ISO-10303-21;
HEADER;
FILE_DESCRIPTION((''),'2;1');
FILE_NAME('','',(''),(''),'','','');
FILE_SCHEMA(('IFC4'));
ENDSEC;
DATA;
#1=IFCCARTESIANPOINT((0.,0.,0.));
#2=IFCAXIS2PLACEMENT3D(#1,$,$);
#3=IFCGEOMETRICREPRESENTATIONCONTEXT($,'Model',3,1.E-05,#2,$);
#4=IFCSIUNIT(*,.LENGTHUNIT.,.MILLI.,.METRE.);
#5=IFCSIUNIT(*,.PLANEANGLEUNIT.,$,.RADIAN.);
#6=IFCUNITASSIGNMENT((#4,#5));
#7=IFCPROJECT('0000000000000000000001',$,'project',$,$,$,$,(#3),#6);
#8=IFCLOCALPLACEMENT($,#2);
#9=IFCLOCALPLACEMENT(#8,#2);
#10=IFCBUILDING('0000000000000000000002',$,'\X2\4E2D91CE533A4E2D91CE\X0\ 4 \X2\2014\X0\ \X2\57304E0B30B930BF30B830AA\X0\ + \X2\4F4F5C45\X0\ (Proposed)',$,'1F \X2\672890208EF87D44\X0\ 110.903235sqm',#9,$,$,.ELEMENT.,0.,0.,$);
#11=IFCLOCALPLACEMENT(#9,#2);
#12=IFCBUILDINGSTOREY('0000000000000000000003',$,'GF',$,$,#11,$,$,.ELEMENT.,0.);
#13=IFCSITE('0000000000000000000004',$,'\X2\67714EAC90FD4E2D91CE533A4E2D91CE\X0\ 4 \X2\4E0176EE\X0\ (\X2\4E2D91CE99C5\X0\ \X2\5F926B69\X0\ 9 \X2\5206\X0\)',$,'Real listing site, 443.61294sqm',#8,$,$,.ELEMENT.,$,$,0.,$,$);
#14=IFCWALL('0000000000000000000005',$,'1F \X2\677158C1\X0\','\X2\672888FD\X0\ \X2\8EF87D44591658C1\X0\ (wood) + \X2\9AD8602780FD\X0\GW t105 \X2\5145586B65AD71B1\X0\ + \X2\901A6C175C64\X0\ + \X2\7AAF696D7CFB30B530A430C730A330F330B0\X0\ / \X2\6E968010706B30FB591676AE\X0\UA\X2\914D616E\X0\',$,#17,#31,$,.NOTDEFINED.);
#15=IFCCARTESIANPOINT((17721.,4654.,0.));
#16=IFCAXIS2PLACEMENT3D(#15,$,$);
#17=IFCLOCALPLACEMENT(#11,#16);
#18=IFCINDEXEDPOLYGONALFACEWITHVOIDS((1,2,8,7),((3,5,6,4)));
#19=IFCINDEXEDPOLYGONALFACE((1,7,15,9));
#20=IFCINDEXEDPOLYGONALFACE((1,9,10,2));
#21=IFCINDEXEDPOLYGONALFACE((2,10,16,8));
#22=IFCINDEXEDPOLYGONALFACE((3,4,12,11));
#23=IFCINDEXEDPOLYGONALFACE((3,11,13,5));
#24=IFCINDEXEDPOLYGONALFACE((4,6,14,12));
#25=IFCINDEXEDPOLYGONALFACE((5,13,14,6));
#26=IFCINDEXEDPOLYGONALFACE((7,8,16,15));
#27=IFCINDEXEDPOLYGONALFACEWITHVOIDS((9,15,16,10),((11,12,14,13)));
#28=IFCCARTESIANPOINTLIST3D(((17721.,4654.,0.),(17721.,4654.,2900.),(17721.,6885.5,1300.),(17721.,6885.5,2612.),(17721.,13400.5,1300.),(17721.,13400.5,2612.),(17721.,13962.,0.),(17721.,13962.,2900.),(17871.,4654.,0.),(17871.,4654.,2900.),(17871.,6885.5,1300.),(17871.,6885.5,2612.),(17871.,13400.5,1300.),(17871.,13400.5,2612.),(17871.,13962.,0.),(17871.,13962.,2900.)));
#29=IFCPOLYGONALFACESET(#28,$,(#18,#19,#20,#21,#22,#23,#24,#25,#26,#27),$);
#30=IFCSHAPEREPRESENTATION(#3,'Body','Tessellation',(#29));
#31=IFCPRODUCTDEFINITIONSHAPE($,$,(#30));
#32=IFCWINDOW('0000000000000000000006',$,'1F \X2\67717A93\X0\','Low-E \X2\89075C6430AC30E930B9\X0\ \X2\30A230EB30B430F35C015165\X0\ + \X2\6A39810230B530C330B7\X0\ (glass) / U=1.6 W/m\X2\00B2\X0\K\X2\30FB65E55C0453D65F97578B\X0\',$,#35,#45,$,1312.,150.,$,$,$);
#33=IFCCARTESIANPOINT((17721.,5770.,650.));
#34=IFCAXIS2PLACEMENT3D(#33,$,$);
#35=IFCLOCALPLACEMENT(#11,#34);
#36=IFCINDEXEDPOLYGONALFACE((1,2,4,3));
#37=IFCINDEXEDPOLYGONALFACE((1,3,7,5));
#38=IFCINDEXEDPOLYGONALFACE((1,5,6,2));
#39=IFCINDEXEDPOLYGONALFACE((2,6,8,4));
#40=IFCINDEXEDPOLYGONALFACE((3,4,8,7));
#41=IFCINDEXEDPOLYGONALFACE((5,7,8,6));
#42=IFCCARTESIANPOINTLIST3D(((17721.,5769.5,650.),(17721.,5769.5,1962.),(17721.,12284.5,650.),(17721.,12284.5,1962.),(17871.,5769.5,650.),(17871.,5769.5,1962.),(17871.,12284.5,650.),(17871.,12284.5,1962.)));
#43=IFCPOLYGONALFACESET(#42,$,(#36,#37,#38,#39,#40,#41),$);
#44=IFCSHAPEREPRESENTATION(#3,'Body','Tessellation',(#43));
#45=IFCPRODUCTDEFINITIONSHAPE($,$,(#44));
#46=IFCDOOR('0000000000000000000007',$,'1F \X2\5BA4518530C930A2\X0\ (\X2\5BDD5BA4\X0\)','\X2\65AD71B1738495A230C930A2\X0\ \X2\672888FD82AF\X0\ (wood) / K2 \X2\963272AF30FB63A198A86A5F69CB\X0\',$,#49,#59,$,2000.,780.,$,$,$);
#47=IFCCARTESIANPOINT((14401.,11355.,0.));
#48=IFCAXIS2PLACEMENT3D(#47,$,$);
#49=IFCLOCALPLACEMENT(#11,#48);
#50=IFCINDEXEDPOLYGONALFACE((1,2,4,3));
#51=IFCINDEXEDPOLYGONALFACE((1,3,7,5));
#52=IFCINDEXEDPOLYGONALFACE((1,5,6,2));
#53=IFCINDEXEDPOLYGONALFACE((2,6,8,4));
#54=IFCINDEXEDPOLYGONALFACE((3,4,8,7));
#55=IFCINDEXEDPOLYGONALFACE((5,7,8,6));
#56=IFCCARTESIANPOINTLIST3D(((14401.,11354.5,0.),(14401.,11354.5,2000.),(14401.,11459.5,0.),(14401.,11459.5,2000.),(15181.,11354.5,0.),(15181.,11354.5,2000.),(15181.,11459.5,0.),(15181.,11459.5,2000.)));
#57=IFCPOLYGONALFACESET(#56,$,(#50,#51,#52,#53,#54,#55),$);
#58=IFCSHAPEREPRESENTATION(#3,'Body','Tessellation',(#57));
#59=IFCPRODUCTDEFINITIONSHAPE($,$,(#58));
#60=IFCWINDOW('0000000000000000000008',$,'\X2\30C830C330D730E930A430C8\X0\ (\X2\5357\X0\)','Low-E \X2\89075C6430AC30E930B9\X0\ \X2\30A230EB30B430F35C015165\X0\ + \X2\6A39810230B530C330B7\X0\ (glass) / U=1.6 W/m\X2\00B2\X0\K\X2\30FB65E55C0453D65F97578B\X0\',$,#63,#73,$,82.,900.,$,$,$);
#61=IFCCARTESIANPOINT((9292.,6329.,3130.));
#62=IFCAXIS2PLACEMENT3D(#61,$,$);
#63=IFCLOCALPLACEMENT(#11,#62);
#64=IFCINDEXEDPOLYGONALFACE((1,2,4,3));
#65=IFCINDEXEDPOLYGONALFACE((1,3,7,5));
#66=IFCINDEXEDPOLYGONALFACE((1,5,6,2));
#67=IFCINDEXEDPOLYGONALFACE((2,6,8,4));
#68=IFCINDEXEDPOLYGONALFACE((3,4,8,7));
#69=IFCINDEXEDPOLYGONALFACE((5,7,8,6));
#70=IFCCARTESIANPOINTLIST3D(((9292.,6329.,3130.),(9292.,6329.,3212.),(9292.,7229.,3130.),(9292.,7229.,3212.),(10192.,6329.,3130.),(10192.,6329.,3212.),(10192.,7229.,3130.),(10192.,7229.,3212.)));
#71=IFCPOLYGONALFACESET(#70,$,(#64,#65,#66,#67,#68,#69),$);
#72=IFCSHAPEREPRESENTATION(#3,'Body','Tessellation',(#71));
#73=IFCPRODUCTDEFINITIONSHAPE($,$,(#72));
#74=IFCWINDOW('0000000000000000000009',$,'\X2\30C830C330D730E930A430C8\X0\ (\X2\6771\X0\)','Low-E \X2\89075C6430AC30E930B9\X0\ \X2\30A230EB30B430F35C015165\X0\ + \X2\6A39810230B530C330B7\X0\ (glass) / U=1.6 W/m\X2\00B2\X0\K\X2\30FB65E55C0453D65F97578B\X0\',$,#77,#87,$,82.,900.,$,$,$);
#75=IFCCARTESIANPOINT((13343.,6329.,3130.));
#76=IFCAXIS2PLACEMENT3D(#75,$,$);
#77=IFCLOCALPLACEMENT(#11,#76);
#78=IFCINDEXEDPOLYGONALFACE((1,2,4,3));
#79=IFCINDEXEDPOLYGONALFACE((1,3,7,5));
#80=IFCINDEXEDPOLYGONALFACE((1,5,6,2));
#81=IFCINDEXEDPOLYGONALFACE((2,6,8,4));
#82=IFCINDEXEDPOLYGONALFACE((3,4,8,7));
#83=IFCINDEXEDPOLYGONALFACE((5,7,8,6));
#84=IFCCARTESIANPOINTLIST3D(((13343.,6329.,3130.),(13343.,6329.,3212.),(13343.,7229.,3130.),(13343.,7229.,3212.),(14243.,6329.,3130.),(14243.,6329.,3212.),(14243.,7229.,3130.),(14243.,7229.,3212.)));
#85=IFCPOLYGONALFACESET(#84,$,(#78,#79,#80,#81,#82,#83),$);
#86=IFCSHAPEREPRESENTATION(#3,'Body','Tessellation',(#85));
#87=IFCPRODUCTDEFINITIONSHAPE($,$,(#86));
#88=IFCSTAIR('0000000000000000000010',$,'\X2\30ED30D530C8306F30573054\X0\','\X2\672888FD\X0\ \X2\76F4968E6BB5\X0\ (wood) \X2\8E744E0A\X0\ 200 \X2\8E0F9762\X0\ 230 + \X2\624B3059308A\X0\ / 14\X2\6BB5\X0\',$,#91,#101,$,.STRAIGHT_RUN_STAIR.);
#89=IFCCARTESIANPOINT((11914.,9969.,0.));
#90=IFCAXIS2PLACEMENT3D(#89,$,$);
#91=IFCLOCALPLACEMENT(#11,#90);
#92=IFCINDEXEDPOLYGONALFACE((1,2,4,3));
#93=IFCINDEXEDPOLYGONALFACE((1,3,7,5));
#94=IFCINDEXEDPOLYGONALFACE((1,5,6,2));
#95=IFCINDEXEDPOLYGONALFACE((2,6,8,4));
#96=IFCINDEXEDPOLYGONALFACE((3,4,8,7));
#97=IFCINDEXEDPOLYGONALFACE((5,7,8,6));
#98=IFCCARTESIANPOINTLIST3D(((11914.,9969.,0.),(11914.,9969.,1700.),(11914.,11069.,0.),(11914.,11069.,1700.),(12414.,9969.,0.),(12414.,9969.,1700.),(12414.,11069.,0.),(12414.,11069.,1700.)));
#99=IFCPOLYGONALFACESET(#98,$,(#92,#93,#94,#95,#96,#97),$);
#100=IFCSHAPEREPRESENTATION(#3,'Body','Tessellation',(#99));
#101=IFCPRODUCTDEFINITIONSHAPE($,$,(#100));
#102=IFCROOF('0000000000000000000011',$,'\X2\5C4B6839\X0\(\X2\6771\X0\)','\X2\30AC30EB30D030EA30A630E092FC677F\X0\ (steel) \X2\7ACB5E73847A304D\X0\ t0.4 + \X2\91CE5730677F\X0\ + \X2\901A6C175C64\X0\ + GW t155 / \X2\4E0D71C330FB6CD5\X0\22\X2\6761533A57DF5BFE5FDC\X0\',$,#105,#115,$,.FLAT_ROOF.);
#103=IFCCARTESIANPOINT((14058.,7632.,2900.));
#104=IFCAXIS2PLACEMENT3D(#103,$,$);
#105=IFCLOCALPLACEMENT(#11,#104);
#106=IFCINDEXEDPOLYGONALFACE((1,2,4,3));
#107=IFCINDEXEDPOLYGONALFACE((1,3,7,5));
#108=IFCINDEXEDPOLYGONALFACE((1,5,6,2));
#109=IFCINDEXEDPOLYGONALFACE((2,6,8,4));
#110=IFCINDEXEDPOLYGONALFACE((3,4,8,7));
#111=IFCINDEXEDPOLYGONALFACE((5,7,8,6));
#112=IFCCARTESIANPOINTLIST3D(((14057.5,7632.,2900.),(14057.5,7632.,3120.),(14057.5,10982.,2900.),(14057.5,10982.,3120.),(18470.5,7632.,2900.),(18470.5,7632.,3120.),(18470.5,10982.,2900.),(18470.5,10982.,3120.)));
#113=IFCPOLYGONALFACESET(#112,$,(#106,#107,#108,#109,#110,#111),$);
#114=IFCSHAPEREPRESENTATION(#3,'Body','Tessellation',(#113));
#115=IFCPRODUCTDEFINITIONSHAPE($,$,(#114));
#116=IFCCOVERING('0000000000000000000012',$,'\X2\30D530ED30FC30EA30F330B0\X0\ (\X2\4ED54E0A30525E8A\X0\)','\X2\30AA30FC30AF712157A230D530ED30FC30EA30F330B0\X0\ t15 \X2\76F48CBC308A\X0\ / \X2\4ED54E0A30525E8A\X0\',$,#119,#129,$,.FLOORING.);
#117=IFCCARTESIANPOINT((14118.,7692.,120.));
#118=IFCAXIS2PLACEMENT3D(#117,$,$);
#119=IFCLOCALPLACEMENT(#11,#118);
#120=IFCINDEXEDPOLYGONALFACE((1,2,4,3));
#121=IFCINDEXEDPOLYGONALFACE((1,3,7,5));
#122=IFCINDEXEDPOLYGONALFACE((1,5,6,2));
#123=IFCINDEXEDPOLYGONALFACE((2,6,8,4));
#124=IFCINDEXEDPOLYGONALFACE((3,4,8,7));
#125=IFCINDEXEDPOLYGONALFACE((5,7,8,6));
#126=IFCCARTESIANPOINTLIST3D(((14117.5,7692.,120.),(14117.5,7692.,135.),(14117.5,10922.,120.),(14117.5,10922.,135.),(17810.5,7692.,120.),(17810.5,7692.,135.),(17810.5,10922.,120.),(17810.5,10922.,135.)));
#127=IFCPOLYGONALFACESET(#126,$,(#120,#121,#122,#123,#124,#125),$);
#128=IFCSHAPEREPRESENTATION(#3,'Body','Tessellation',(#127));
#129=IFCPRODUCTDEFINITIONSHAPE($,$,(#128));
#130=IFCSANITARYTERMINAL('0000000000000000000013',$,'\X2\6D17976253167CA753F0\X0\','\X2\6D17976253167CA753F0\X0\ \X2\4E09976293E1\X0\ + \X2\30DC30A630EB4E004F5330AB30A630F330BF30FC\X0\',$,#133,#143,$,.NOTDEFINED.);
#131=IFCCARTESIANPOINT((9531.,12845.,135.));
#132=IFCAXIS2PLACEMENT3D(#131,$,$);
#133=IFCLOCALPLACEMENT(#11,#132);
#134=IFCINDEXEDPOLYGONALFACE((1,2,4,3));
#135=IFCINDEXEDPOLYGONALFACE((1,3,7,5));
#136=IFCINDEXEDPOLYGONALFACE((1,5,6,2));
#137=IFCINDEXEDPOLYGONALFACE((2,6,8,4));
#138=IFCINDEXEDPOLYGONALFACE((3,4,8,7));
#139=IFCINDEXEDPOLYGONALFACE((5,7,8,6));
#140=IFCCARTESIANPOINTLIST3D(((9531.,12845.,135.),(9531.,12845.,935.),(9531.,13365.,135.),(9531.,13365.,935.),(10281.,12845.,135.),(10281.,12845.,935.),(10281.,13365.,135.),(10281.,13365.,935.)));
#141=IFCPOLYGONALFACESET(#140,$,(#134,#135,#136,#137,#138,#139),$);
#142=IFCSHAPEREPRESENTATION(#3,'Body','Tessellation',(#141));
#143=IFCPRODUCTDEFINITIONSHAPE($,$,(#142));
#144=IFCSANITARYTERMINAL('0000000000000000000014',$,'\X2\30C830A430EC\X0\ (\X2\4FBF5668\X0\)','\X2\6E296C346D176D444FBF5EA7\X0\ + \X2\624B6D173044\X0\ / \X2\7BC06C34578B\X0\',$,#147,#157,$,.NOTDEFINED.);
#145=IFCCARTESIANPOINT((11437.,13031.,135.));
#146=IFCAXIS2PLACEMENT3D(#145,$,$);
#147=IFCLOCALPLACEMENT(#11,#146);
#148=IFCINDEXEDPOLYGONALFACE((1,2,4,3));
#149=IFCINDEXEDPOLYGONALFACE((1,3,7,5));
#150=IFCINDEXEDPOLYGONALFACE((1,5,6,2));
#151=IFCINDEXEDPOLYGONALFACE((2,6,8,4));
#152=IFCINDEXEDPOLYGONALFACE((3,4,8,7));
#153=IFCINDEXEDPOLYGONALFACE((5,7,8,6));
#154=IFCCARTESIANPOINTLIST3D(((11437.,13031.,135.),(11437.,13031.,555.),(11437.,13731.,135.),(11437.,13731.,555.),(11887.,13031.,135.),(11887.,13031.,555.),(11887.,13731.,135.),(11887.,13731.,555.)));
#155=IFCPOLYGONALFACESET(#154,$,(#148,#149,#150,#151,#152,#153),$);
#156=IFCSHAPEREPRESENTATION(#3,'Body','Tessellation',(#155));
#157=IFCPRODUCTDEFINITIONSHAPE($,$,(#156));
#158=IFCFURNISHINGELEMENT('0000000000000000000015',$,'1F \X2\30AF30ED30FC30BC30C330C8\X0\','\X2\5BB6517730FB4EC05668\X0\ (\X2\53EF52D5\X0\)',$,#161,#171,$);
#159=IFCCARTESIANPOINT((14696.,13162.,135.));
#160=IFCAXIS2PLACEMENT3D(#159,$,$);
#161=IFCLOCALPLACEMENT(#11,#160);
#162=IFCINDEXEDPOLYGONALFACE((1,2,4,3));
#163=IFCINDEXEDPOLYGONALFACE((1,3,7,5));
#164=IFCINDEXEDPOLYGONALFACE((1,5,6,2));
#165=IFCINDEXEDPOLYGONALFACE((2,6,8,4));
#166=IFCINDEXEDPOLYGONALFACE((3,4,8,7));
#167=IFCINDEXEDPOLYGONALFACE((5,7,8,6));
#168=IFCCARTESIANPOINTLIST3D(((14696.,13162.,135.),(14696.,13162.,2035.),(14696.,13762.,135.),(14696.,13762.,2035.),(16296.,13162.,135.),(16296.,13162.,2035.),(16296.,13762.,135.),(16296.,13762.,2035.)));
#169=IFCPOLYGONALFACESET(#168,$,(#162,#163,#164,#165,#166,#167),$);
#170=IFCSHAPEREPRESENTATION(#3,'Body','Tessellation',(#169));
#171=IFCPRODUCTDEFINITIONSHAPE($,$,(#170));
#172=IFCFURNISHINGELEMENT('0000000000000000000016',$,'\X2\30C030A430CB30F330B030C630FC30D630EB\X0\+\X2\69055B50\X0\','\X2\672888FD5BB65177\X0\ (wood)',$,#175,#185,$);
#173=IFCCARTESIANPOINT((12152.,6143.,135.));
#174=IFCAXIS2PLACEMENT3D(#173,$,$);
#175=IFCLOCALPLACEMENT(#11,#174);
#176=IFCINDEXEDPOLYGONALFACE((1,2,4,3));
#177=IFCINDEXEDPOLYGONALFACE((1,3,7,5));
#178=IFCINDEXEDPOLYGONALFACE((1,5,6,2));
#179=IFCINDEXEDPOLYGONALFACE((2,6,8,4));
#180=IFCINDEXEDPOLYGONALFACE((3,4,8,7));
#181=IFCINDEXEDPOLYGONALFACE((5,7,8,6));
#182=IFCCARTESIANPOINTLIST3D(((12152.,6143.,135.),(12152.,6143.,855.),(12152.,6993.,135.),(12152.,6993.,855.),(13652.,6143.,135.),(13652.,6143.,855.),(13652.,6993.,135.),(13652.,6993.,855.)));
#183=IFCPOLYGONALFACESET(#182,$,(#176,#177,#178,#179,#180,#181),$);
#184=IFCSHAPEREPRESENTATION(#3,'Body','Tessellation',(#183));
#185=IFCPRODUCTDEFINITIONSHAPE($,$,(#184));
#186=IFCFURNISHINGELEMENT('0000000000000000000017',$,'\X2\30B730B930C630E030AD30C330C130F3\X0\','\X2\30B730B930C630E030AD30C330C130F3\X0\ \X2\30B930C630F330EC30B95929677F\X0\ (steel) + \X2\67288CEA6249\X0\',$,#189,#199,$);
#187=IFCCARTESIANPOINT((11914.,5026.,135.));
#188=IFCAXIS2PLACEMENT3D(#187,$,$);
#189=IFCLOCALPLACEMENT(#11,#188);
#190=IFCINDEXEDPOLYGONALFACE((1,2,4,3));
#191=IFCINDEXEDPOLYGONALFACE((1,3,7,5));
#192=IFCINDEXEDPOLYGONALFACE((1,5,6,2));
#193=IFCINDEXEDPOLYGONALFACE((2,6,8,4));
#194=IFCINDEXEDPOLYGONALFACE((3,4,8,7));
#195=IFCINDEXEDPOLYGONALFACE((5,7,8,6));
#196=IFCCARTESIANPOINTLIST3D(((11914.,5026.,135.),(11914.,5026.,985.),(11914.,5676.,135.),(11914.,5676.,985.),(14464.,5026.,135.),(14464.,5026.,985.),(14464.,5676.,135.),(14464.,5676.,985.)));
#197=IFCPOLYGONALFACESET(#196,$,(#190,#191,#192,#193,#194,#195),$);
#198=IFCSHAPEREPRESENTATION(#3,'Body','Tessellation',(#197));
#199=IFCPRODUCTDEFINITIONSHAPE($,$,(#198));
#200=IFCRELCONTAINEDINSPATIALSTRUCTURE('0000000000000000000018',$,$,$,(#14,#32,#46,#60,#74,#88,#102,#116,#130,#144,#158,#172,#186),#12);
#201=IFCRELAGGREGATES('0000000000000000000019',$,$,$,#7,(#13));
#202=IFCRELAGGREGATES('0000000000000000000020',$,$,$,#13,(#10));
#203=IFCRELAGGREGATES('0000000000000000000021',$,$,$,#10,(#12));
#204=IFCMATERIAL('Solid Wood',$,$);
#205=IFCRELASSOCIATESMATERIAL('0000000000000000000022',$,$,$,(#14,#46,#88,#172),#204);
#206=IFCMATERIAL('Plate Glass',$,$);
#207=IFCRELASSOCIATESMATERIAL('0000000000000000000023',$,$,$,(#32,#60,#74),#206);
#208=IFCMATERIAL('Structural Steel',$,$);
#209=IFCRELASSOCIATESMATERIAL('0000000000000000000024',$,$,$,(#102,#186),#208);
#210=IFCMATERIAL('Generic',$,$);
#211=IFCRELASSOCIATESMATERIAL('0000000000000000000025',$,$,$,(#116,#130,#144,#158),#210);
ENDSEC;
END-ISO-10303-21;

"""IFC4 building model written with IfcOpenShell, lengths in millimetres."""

from ifc_helpers import new_model, si_unit, frame, frame_2d, origin, place, context, project, spatial, rectangle, extrude, material, element, fill, save


model = new_model("IFC4")

# Units and contexts
model_context = context("Model", 3, precision=1e-05, world=origin())
ifc_project = project(units=[si_unit("LENGTHUNIT", "METRE", prefix="MILLI"), si_unit("PLANEANGLEUNIT", "RADIAN")], contexts=[model_context])

# Site, building, storey
site_placement = place(None, origin())
site = spatial("IfcSite", under=ifc_project, at=site_placement, Name="東京都中野区中野 4 丁目 (中野駅 徒歩 9 分)", ObjectType="Real listing site, 443.61294sqm", CompositionType="ELEMENT", RefElevation=0.0)
building_placement = place(site_placement, origin())
building = spatial("IfcBuilding", under=site, at=building_placement, Name="中野区中野 4 — 地下スタジオ + 住居 (Proposed)", ObjectType="1F 木造軸組 110.903235sqm", CompositionType="ELEMENT", ElevationOfRefHeight=0.0, ElevationOfTerrain=0.0)
storey_placement = place(building_placement, origin())
storey = spatial("IfcBuildingStorey", under=building, at=storey_placement, Name="GF", CompositionType="ELEMENT", Elevation=0.0)

# Shared definitions
ifc_material_1 = material(Name="Solid Wood")

# Wall, opening, window
wall_1_placement = place(storey_placement, frame((17721.0, 4654.0, 0.0)))
wall_1 = element("IfcWall", 1, at=wall_1_placement, inside=storey, material=ifc_material_1, Name="1F 東壁", Description="木製 軸組外壁 (wood) + 高性能GW t105 充填断熱 + 通気層 + 窯業系サイディング / 準耐火・外皮UA配慮", PredefinedType="NOTDEFINED", context=model_context, shape_type="SweptSolid", body=[
    extrude(rectangle(XDim=150.0, YDim=9308.0, at=frame_2d((75.0, 4654.0))), frame((17721.0, 4654.0, 0.0)), (0.0, 0.0, 1.0), 2900.0),
])
opening_1_placement = place(storey_placement, frame((17721.0, 5770.0, 650.0)))
opening_1 = element("IfcOpeningElement", 2, at=opening_1_placement, cuts=wall_1, PredefinedType="NOTDEFINED", context=model_context, shape_type="SweptSolid", body=[
    extrude(rectangle(XDim=150.0, YDim=6515.0, at=frame_2d((75.0, 3257.0))), frame((17721.0, 5770.0, 650.0)), (0.0, 0.0, 1.0), 1312.0),
])
ifc_material_2 = material(Name="Plate Glass")
window_1_placement = place(storey_placement, frame((17721.0, 5770.0, 650.0)))
window_1 = element("IfcWindow", 3, at=window_1_placement, inside=storey, material=ifc_material_2, Name="1F 東窓", Description="Low-E 複層ガラス アルゴン封入 + 樹脂サッシ (glass) / U=1.6 W/m²K・日射取得型", OverallHeight=1312.0, OverallWidth=150.0, context=model_context, shape_type="SweptSolid", body=[
    extrude(rectangle(XDim=150.0, YDim=6515.0, at=frame_2d((75.0, 3257.0))), frame((17721.0, 5770.0, 650.0)), (0.0, 0.0, 1.0), 1312.0),
])
fill(opening_1, window_1)

# Door
door_placement = place(storey_placement, frame((14401.0, 11355.0, 0.0)))
element("IfcDoor", 4, at=door_placement, inside=storey, material=ifc_material_1, Name="1F 室内ドア (寝室)", Description="断熱玄関ドア 木製芯 (wood) / K2 防犯・採風機構", OverallHeight=2000.0, OverallWidth=780.0, context=model_context, shape_type="SweptSolid", body=[
    extrude(rectangle(XDim=780.0, YDim=105.0, at=frame_2d((390.0, 52.0))), frame((14401.0, 11355.0, 0.0)), (0.0, 0.0, 1.0), 2000.0),
])

# Windows
window_2_placement = place(storey_placement, frame((9292.0, 6329.0, 3130.0)))
element("IfcWindow", 5, at=window_2_placement, inside=storey, material=ifc_material_2, Name="トップライト (南)", Description="Low-E 複層ガラス アルゴン封入 + 樹脂サッシ (glass) / U=1.6 W/m²K・日射取得型", OverallHeight=82.0, OverallWidth=900.0, context=model_context, shape_type="SweptSolid", body=[
    extrude(rectangle(XDim=900.0, YDim=900.0, at=frame_2d((450.0, 450.0))), frame((9292.0, 6329.0, 3130.0)), (0.0, 0.0, 1.0), 82.0),
])
window_3_placement = place(storey_placement, frame((13343.0, 6329.0, 3130.0)))
element("IfcWindow", 6, at=window_3_placement, inside=storey, material=ifc_material_2, Name="トップライト (東)", Description="Low-E 複層ガラス アルゴン封入 + 樹脂サッシ (glass) / U=1.6 W/m²K・日射取得型", OverallHeight=82.0, OverallWidth=900.0, context=model_context, shape_type="SweptSolid", body=[
    extrude(rectangle(XDim=900.0, YDim=900.0, at=frame_2d((450.0, 450.0))), frame((13343.0, 6329.0, 3130.0)), (0.0, 0.0, 1.0), 82.0),
])

# Stair
stair_placement = place(storey_placement, frame((11914.0, 9969.0, 0.0)))
element("IfcStair", 7, at=stair_placement, inside=storey, material=ifc_material_1, Name="ロフトはしご", Description="木製 直階段 (wood) 蹴上 200 踏面 230 + 手すり / 14段", PredefinedType="STRAIGHT_RUN_STAIR", context=model_context, shape_type="SweptSolid", body=[
    extrude(rectangle(XDim=500.0, YDim=1100.0, at=frame_2d((250.0, 550.0))), frame((11914.0, 9969.0, 0.0)), (0.0, 0.0, 1.0), 1700.0),
])

# Roof
ifc_material_3 = material(Name="Structural Steel")
roof_placement = place(storey_placement, frame((14058.0, 7632.0, 2900.0)))
element("IfcRoof", 8, at=roof_placement, inside=storey, material=ifc_material_3, Name="屋根(東)", Description="ガルバリウム鋼板 (steel) 立平葺き t0.4 + 野地板 + 通気層 + GW t155 / 不燃・法22条区域対応", PredefinedType="FLAT_ROOF", context=model_context, shape_type="SweptSolid", body=[
    extrude(rectangle(XDim=4413.0, YDim=3350.0, at=frame_2d((2206.0, 1675.0))), frame((14058.0, 7632.0, 2900.0)), (0.0, 0.0, 1.0), 220.0),
])

# Covering
ifc_material_4 = material(Name="Generic")
covering_placement = place(storey_placement, frame((14118.0, 7692.0, 120.0)))
element("IfcCovering", 9, at=covering_placement, inside=storey, material=ifc_material_4, Name="フローリング (仕上げ床)", Description="オーク無垢フローリング t15 直貼り / 仕上げ床", PredefinedType="FLOORING", context=model_context, shape_type="SweptSolid", body=[
    extrude(rectangle(XDim=3693.0, YDim=3230.0, at=frame_2d((1846.0, 1615.0))), frame((14118.0, 7692.0, 120.0)), (0.0, 0.0, 1.0), 15.0),
])

# Sanitary terminals
sanitary_terminal_1_placement = place(storey_placement, frame((9531.0, 12845.0, 135.0)))
element("IfcSanitaryTerminal", 10, at=sanitary_terminal_1_placement, inside=storey, material=ifc_material_4, Name="洗面化粧台", Description="洗面化粧台 三面鏡 + ボウル一体カウンター", PredefinedType="NOTDEFINED", context=model_context, shape_type="SweptSolid", body=[
    extrude(rectangle(XDim=750.0, YDim=520.0, at=frame_2d((375.0, 260.0))), frame((9531.0, 12845.0, 135.0)), (0.0, 0.0, 1.0), 800.0),
])
sanitary_terminal_2_placement = place(storey_placement, frame((11437.0, 13031.0, 135.0)))
element("IfcSanitaryTerminal", 11, at=sanitary_terminal_2_placement, inside=storey, material=ifc_material_4, Name="トイレ (便器)", Description="温水洗浄便座 + 手洗い / 節水型", PredefinedType="NOTDEFINED", context=model_context, shape_type="SweptSolid", body=[
    extrude(rectangle(XDim=450.0, YDim=700.0, at=frame_2d((225.0, 350.0))), frame((11437.0, 13031.0, 135.0)), (0.0, 0.0, 1.0), 420.0),
])

# Furnishing elements
furnishing_1_placement = place(storey_placement, frame((14696.0, 13162.0, 135.0)))
element("IfcFurnishingElement", 12, at=furnishing_1_placement, inside=storey, material=ifc_material_4, Name="1F クローゼット", Description="家具・什器 (可動)", context=model_context, shape_type="SweptSolid", body=[
    extrude(rectangle(XDim=1600.0, YDim=600.0, at=frame_2d((800.0, 300.0))), frame((14696.0, 13162.0, 135.0)), (0.0, 0.0, 1.0), 1900.0),
])
furnishing_2_placement = place(storey_placement, frame((12152.0, 6143.0, 135.0)))
element("IfcFurnishingElement", 13, at=furnishing_2_placement, inside=storey, material=ifc_material_1, Name="ダイニングテーブル+椅子", Description="木製家具 (wood)", context=model_context, shape_type="SweptSolid", body=[
    extrude(rectangle(XDim=1500.0, YDim=850.0, at=frame_2d((750.0, 425.0))), frame((12152.0, 6143.0, 135.0)), (0.0, 0.0, 1.0), 720.0),
])
furnishing_3_placement = place(storey_placement, frame((11914.0, 5026.0, 135.0)))
element("IfcFurnishingElement", 14, at=furnishing_3_placement, inside=storey, material=ifc_material_3, Name="システムキッチン", Description="システムキッチン ステンレス天板 (steel) + 木質扉", context=model_context, shape_type="SweptSolid", body=[
    extrude(rectangle(XDim=2550.0, YDim=650.0, at=frame_2d((1275.0, 325.0))), frame((11914.0, 5026.0, 135.0)), (0.0, 0.0, 1.0), 850.0),
])

save(model, "model.ifc")
